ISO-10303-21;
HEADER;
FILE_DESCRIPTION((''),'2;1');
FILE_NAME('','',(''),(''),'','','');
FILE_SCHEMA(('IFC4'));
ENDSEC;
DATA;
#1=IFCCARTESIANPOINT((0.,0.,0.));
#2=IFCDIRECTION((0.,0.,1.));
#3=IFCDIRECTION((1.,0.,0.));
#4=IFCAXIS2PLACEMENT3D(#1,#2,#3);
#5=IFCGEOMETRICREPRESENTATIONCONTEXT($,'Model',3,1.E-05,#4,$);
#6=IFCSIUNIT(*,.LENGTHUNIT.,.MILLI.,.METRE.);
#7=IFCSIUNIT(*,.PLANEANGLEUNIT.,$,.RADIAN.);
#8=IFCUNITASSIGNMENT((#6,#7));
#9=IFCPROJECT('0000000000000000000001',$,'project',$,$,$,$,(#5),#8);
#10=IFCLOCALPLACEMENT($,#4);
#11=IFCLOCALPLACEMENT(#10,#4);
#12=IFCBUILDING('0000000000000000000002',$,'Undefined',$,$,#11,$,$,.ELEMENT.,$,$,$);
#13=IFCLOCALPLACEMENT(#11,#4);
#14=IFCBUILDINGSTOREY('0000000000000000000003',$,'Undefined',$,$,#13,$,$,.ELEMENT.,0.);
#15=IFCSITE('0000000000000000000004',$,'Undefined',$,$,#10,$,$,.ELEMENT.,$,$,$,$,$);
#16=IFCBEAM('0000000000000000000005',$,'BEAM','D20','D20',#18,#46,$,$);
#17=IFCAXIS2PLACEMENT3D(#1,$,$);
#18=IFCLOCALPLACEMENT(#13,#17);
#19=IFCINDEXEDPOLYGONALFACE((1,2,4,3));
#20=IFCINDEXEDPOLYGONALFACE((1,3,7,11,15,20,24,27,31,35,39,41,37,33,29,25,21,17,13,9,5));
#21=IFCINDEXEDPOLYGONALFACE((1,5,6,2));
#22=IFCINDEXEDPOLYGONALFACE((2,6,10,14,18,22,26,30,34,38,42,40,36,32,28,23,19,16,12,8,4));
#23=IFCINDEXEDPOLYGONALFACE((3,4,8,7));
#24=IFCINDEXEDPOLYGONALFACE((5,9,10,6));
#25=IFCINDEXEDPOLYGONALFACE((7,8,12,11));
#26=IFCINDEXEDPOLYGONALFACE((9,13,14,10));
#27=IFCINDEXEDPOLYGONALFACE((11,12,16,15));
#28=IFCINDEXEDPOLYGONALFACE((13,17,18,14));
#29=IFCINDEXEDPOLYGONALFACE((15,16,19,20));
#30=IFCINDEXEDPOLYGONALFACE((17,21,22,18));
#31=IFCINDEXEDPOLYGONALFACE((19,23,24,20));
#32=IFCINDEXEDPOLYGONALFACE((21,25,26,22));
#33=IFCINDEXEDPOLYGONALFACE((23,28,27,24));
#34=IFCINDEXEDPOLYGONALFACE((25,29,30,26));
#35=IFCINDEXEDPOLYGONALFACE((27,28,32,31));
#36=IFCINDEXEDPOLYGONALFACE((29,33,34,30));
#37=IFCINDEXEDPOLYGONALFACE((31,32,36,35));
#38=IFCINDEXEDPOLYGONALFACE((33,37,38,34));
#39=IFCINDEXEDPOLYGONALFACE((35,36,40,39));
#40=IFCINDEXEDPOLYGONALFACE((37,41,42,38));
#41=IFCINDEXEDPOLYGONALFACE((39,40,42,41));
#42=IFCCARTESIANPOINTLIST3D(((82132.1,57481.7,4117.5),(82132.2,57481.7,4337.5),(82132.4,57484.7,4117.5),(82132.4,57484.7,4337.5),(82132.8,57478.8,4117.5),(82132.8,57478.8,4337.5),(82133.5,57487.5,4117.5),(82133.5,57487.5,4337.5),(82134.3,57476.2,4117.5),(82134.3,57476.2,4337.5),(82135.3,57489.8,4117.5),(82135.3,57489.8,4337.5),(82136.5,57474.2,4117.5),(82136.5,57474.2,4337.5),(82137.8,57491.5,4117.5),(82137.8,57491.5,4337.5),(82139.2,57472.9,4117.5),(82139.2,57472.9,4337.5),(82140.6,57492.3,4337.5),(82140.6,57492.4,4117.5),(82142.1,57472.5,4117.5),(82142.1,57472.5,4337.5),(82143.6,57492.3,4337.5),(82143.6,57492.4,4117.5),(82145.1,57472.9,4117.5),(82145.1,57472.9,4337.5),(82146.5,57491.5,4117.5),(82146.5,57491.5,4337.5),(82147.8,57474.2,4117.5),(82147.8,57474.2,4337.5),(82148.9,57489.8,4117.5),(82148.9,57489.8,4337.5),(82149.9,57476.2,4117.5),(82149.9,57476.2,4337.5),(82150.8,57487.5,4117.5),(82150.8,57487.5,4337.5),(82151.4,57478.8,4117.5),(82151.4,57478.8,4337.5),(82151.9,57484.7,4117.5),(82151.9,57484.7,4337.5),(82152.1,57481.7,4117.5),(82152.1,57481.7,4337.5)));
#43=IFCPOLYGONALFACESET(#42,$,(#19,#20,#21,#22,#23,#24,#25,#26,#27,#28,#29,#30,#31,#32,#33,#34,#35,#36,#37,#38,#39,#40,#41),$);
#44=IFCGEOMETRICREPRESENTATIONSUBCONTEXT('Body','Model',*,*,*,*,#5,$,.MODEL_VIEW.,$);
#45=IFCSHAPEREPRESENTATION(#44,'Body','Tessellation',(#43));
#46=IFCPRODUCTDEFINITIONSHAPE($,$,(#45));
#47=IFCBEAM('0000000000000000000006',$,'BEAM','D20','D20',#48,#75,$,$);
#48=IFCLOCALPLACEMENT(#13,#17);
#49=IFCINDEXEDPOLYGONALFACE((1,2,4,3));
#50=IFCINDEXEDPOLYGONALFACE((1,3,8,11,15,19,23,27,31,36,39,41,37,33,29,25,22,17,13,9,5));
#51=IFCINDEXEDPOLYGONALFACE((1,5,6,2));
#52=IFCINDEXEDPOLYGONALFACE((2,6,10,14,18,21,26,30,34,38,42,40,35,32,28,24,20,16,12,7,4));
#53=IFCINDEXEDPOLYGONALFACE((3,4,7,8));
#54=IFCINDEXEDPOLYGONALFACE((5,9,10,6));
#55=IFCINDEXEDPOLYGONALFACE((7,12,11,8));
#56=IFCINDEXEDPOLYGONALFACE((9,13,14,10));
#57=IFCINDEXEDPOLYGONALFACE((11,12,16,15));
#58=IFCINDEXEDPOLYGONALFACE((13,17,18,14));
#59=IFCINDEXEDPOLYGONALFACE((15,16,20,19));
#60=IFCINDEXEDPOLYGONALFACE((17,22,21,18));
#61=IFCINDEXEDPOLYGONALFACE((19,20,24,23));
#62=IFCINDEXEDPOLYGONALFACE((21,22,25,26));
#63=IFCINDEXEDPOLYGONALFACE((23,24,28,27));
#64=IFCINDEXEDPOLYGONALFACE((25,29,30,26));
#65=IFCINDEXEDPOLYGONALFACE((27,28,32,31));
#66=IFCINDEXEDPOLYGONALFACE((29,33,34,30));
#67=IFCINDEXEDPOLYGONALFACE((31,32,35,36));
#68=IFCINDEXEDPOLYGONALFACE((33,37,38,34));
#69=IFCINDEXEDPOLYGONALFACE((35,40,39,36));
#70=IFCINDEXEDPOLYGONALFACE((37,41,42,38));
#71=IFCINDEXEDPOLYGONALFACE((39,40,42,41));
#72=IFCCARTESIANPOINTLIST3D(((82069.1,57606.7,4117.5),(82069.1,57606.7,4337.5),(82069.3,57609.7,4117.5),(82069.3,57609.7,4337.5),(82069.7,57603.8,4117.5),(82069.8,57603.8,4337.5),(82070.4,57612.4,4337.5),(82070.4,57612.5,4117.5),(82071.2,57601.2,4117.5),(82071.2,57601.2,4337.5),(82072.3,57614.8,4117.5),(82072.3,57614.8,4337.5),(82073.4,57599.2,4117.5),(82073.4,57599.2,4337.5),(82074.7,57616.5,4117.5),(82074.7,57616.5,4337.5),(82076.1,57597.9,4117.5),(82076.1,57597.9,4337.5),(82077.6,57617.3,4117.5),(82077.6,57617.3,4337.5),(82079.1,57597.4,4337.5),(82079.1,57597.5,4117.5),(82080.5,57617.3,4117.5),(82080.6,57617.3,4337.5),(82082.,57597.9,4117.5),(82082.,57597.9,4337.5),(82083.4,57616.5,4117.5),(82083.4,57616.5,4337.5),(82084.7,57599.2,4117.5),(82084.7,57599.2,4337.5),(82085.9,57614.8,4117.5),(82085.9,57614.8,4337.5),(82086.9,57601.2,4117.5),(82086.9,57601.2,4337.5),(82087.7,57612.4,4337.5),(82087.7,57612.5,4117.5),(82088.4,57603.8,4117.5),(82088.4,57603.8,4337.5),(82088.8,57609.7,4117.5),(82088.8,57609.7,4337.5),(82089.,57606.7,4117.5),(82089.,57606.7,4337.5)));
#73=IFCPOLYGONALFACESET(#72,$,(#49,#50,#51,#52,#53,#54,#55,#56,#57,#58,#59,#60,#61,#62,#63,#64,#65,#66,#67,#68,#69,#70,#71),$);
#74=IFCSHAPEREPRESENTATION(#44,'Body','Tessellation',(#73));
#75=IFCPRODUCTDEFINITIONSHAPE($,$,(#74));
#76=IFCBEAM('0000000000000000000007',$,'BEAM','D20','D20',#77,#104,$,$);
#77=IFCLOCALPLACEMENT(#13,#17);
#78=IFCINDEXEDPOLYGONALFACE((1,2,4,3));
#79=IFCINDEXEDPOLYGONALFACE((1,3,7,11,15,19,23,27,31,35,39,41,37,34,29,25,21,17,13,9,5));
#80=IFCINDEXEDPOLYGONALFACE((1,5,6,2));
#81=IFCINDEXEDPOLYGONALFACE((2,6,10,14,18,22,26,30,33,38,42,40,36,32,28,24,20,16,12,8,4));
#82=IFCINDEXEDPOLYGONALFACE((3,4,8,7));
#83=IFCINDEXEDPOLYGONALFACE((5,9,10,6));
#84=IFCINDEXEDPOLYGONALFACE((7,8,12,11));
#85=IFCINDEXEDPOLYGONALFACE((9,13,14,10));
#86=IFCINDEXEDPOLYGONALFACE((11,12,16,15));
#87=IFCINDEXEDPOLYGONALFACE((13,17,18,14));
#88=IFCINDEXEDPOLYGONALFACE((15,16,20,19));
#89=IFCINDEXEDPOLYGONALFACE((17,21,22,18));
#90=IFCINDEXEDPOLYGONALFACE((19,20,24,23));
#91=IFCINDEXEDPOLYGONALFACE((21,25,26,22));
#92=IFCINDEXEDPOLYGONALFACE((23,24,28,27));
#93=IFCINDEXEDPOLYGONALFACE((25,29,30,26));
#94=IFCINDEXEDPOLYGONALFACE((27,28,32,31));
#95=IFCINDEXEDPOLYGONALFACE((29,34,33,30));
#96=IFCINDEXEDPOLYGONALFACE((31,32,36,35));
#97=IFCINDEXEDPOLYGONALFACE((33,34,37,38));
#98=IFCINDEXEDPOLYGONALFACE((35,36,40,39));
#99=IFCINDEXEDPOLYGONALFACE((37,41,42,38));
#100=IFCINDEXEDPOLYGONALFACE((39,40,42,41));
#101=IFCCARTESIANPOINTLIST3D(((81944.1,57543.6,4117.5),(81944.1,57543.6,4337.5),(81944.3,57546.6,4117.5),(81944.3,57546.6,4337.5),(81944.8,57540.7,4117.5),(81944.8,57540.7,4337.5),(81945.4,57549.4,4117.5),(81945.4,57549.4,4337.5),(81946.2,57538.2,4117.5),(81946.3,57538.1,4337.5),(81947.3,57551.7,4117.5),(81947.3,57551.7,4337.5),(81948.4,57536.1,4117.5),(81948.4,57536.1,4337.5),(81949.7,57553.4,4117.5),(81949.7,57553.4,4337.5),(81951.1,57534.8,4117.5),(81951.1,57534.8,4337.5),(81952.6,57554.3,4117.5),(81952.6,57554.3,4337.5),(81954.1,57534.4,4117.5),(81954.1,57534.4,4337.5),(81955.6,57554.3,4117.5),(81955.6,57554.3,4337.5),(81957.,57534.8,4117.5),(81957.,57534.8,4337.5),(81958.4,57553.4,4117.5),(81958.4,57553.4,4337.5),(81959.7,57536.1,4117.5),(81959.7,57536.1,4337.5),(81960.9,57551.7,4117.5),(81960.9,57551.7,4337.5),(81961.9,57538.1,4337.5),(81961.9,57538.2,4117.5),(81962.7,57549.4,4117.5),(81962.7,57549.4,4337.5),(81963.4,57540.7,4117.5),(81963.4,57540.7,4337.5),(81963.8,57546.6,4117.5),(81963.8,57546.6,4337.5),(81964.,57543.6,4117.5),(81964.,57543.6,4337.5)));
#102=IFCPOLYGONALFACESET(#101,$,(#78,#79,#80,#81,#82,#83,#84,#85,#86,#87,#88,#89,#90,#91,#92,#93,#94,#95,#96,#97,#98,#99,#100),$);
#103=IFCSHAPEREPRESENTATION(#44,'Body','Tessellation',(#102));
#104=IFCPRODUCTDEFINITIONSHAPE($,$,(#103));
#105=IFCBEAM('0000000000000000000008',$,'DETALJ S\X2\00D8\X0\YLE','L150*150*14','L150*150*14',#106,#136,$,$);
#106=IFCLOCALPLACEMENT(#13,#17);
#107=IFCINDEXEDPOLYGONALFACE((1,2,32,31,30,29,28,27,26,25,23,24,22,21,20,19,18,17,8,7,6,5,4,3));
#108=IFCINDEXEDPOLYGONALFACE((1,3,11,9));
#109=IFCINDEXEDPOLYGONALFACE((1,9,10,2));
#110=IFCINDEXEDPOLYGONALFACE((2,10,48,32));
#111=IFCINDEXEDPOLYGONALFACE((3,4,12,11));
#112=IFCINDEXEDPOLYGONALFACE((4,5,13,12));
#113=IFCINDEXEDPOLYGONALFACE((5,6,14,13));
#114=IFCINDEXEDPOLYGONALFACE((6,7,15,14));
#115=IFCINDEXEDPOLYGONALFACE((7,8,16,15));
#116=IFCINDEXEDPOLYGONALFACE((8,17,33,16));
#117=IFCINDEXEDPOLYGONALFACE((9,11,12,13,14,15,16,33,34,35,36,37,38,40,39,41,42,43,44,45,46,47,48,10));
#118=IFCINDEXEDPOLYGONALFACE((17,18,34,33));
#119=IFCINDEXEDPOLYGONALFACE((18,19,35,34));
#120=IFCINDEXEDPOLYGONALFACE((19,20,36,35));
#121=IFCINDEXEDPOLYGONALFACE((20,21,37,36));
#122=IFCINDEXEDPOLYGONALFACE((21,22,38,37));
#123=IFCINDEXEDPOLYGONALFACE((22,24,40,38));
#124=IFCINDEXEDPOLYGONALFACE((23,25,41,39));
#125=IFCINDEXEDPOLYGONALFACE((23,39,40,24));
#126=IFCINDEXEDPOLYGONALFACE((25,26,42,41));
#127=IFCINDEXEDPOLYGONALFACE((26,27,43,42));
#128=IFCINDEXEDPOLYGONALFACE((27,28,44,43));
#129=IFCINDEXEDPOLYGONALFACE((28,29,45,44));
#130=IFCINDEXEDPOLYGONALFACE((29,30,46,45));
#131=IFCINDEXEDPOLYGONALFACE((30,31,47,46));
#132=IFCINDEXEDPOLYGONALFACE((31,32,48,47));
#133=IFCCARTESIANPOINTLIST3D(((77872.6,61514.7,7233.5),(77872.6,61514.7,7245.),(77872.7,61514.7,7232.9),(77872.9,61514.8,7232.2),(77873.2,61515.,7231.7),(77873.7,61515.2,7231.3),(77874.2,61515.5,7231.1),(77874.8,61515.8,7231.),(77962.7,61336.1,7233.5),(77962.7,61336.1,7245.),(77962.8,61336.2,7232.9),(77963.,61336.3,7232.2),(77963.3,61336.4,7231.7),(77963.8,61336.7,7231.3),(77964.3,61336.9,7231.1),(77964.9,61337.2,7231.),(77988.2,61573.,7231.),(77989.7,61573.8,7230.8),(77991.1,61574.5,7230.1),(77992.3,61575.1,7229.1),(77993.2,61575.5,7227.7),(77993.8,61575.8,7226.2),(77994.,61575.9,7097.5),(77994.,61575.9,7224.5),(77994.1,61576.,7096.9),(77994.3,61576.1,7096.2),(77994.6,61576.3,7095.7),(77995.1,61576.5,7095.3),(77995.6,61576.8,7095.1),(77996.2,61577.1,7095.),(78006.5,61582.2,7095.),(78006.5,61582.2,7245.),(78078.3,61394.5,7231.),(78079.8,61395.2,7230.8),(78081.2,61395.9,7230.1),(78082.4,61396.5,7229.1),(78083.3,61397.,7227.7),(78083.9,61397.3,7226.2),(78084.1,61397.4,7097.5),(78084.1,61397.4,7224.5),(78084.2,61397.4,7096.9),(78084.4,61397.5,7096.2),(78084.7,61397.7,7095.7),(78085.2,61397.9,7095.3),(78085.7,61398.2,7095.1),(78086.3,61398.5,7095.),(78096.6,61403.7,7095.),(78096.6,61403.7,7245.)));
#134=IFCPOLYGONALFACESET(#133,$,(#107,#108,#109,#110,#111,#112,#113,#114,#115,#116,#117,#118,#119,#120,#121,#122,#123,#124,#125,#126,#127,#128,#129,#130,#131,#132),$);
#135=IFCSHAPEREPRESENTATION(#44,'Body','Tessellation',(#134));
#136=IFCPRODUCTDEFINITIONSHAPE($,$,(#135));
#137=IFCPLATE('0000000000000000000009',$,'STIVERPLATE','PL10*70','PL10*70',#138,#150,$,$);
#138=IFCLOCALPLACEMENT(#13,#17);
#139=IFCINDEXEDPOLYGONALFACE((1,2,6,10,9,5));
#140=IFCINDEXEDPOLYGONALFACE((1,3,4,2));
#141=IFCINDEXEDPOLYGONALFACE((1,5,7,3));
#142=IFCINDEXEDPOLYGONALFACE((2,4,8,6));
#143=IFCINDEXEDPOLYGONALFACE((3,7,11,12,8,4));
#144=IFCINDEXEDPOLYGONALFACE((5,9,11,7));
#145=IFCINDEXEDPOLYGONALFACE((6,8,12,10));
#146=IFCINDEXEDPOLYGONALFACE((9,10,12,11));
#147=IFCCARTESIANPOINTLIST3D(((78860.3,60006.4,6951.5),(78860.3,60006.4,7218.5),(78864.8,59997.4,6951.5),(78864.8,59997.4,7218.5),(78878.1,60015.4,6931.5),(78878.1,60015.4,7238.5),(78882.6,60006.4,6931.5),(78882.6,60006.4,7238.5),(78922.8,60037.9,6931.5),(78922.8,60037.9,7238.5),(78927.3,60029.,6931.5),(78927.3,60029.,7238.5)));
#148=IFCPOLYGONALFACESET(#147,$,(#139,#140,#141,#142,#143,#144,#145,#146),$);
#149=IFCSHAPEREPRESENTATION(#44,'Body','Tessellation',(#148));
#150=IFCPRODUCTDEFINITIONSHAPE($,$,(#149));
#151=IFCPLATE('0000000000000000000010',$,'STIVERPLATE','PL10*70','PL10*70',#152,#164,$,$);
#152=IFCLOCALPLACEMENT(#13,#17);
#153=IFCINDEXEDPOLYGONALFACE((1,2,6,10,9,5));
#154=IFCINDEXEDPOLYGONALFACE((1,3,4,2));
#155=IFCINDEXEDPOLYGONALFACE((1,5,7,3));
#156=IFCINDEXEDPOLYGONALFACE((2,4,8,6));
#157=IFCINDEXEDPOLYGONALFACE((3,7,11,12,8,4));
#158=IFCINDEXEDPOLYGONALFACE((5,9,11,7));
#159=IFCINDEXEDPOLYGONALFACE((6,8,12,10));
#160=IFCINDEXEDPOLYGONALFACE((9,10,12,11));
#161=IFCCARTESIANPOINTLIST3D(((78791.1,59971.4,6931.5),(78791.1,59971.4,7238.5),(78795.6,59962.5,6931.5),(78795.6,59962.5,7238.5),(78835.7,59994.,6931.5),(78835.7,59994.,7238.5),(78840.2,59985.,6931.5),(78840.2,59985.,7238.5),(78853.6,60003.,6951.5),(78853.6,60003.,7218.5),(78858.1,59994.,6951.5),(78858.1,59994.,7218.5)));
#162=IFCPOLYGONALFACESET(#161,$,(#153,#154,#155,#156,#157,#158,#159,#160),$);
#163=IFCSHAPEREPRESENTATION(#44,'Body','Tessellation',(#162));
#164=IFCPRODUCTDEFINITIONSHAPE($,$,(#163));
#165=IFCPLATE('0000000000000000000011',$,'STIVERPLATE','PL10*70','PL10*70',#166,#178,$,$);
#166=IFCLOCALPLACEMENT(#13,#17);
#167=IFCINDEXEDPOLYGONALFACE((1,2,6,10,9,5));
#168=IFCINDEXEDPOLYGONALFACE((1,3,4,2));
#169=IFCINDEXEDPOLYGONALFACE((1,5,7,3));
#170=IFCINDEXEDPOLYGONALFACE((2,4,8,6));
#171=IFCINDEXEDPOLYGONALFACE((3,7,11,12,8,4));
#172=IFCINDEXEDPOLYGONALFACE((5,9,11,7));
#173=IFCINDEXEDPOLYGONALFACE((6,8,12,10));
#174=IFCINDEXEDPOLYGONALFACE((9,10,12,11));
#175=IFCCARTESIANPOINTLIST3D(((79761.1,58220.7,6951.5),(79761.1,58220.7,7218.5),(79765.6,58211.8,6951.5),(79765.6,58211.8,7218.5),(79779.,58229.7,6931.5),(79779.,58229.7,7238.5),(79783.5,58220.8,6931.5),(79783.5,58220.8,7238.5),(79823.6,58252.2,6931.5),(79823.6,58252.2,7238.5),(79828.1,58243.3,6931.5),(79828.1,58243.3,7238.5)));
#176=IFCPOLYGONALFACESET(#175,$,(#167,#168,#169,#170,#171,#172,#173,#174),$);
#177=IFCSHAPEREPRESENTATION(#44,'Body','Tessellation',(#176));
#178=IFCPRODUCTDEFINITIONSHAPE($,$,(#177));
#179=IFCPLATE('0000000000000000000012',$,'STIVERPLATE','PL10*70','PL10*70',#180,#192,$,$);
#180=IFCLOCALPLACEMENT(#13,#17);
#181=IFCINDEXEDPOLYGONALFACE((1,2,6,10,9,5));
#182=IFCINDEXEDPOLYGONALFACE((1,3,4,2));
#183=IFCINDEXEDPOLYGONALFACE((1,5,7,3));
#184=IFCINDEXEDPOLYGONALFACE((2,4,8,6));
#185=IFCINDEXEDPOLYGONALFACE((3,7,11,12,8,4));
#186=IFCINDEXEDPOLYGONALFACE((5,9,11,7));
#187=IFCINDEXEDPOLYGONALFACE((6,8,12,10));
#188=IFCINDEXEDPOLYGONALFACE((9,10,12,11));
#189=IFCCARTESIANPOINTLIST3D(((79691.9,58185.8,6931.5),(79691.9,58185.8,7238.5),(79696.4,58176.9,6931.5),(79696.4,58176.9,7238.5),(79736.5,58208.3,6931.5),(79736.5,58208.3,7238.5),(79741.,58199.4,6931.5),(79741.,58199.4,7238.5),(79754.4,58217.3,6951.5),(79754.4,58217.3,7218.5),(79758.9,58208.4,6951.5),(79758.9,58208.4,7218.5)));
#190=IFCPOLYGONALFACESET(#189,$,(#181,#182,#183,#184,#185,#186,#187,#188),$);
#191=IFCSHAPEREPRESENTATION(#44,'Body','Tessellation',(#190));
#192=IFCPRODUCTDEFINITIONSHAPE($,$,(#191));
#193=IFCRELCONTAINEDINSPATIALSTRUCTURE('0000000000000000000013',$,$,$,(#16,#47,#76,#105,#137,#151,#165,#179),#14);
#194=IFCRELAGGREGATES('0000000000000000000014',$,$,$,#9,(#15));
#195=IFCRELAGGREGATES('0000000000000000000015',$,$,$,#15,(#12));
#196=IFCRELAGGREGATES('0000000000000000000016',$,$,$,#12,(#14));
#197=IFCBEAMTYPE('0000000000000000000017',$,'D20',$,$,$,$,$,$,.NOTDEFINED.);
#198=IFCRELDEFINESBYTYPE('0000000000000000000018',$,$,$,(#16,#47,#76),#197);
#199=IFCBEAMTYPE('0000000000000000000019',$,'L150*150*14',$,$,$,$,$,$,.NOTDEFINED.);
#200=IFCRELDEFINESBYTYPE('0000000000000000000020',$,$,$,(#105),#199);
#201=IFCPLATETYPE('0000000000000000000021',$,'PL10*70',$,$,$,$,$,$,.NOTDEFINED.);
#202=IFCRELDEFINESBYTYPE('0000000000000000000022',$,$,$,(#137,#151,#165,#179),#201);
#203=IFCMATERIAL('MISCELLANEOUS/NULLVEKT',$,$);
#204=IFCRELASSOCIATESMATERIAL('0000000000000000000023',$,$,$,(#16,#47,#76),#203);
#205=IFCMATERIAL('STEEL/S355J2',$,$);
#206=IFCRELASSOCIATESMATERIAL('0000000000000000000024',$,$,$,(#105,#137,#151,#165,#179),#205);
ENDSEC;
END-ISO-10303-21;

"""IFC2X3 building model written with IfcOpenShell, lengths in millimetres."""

from ifc_helpers import new_model, si_unit, frame, origin_with_axes, origin_2d_with_axis, place, context, subcontext, project, spatial, polyline, circle, l_section, outline, extrude, material, type_object, element, save


model = new_model("IFC2X3")

# Units and contexts
model_context = context("Model", 3, precision=1e-05, world=origin_with_axes())
body_context = subcontext(model_context, "Body", "Model", "MODEL_VIEW")
ifc_project = project(units=[si_unit("LENGTHUNIT", "METRE", prefix="MILLI"), si_unit("PLANEANGLEUNIT", "RADIAN")], contexts=[model_context])

# Site, building, storey
site_placement = place(None, origin_with_axes())
site = spatial("IfcSite", under=ifc_project, at=site_placement, Name="Undefined", CompositionType="ELEMENT")
building_placement = place(site_placement, origin_with_axes())
building = spatial("IfcBuilding", under=site, at=building_placement, Name="Undefined", CompositionType="ELEMENT")
storey_placement = place(building_placement, origin_with_axes())
storey = spatial("IfcBuildingStorey", under=building, at=storey_placement, Name="Undefined", CompositionType="ELEMENT", Elevation=0.0)

# Shared definitions
ifc_material_1 = material(Name="STEEL/S355J2")

# Beams
ifc_material_2 = material(Name="MISCELLANEOUS/NULLVEKT")
beam_type_1 = type_object("IfcBeamType", Name="D20", PredefinedType="NOTDEFINED")
for number, where, z_axis, x_axis, name in (
    (1, (82142.1, 57482.5, 4337.5), (1.0, 0.0, -0.000032), (-0.000032, 0.000048, -1.0), "BEAM"),
    (2, (82079.1, 57607.4, 4337.5), (1.0, 0.0, -0.000032), (-0.000032, 0.000048, -1.0), "BEAM"),
    (3, (81954.1, 57544.4, 4337.5), (1.0, 0.0, -0.000032), (-0.000032, 0.000048, -1.0), "BEAM"),
):
    element("IfcBeam", number, at=place(storey_placement, frame(where, z_axis=z_axis, x_axis=x_axis)), inside=storey, type_object=beam_type_1, material=ifc_material_2, Name=name, Description="D20", ObjectType="D20", context=body_context, shape_type="SweptSolid", body=[
        extrude(circle(Radius=10.0, at=origin_2d_with_axis()), frame((220.0, 0.0, 0.0), z_axis=(-1.0, 0.0, 0.0), x_axis=(0.0, -1.0, 0.0)), (0.0, 0.0, 1.0), 220.0),
    ])
beam_type_2 = type_object("IfcBeamType", Name="L150*150*14", PredefinedType="NOTDEFINED")
beam_1_placement = place(storey_placement, frame((77939.5, 61548.5, 7170.0), z_axis=(-0.892774, -0.450504, 0.0), x_axis=(0.450504, -0.892774, 0.0)))
element("IfcBeam", 4, at=beam_1_placement, inside=storey, type_object=beam_type_2, material=ifc_material_1, Name="DETALJ SØYLE", Description="L150*150*14", ObjectType="L150*150*14", context=body_context, shape_type="SweptSolid", body=[
    extrude(l_section(Depth=150.0, Width=150.0, Thickness=14.0, FilletRadius=6.5, EdgeRadius=2.5, at=origin_2d_with_axis()), frame((200.0, 0.0, 0.0), z_axis=(-1.0, 0.0, 0.0), x_axis=(0.0, -1.0, 0.0)), (0.0, 0.0, 1.0), 200.0),
])

# Plates
plate_type_1 = type_object("IfcPlateType", Name="PL10*70", PredefinedType="NOTDEFINED")
plate_1_placement = place(storey_placement, frame((78925.0, 60033.4, 6931.5), z_axis=(-0.45041, 0.892822, 0.0), x_axis=(-0.892821, -0.450411, 0.0)))
element("IfcPlate", 5, at=plate_1_placement, inside=storey, type_object=plate_type_1, material=ifc_material_1, Name="STIVERPLATE", Description="PL10*70", ObjectType="PL10*70", context=body_context, shape_type="SweptSolid", body=[
    extrude(outline(polyline([(0.0, 0.0), (50.0, 0.0), (70.0, 20.0), (70.0, 287.0), (50.0, 307.0), (0.0, 307.0), (0.0, 0.0)])), frame((0.0, 0.0, -5.0), z_axis=(0.0, 0.0, 1.0), x_axis=(1.0, 0.0, 0.0)), (0.0, 0.0, 1.0), 10.0),
])
plate_2_placement = place(storey_placement, frame((78855.8, 59998.5, 6931.5), z_axis=(-0.45041, 0.892822, 0.0), x_axis=(-0.892821, -0.450411, 0.0)))
element("IfcPlate", 6, at=plate_2_placement, inside=storey, type_object=plate_type_1, material=ifc_material_1, Name="STIVERPLATE", Description="PL10*70", ObjectType="PL10*70", context=body_context, shape_type="SweptSolid", body=[
    extrude(outline(polyline([(0.0, 20.0), (20.0, 0.0), (70.0, 0.0), (70.0, 307.0), (20.0, 307.0), (0.0, 287.0), (0.0, 20.0)])), frame((0.0, 0.0, -5.0), z_axis=(0.0, 0.0, 1.0), x_axis=(1.0, 0.0, 0.0)), (0.0, 0.0, 1.0), 10.0),
])
plate_3_placement = place(storey_placement, frame((79825.8, 58247.8, 6931.5), z_axis=(-0.45041, 0.892822, 0.0), x_axis=(-0.892821, -0.450411, 0.0)))
element("IfcPlate", 7, at=plate_3_placement, inside=storey, type_object=plate_type_1, material=ifc_material_1, Name="STIVERPLATE", Description="PL10*70", ObjectType="PL10*70", context=body_context, shape_type="SweptSolid", body=[
    extrude(outline(polyline([(0.0, 0.0), (50.0, 0.0), (70.0, 20.0), (70.0, 287.0), (50.0, 307.0), (0.0, 307.0), (0.0, 0.0)])), frame((0.0, 0.0, -5.0), z_axis=(0.0, 0.0, 1.0), x_axis=(1.0, 0.0, 0.0)), (0.0, 0.0, 1.0), 10.0),
])
plate_4_placement = place(storey_placement, frame((79756.7, 58212.9, 6931.5), z_axis=(-0.45041, 0.892822, 0.0), x_axis=(-0.892821, -0.450411, 0.0)))
element("IfcPlate", 8, at=plate_4_placement, inside=storey, type_object=plate_type_1, material=ifc_material_1, Name="STIVERPLATE", Description="PL10*70", ObjectType="PL10*70", context=body_context, shape_type="SweptSolid", body=[
    extrude(outline(polyline([(0.0, 20.0), (20.0, 0.0), (70.0, 0.0), (70.0, 307.0), (20.0, 307.0), (0.0, 287.0), (0.0, 20.0)])), frame((0.0, 0.0, -5.0), z_axis=(0.0, 0.0, 1.0), x_axis=(1.0, 0.0, 0.0)), (0.0, 0.0, 1.0), 10.0),
])

save(model, "model.ifc")
